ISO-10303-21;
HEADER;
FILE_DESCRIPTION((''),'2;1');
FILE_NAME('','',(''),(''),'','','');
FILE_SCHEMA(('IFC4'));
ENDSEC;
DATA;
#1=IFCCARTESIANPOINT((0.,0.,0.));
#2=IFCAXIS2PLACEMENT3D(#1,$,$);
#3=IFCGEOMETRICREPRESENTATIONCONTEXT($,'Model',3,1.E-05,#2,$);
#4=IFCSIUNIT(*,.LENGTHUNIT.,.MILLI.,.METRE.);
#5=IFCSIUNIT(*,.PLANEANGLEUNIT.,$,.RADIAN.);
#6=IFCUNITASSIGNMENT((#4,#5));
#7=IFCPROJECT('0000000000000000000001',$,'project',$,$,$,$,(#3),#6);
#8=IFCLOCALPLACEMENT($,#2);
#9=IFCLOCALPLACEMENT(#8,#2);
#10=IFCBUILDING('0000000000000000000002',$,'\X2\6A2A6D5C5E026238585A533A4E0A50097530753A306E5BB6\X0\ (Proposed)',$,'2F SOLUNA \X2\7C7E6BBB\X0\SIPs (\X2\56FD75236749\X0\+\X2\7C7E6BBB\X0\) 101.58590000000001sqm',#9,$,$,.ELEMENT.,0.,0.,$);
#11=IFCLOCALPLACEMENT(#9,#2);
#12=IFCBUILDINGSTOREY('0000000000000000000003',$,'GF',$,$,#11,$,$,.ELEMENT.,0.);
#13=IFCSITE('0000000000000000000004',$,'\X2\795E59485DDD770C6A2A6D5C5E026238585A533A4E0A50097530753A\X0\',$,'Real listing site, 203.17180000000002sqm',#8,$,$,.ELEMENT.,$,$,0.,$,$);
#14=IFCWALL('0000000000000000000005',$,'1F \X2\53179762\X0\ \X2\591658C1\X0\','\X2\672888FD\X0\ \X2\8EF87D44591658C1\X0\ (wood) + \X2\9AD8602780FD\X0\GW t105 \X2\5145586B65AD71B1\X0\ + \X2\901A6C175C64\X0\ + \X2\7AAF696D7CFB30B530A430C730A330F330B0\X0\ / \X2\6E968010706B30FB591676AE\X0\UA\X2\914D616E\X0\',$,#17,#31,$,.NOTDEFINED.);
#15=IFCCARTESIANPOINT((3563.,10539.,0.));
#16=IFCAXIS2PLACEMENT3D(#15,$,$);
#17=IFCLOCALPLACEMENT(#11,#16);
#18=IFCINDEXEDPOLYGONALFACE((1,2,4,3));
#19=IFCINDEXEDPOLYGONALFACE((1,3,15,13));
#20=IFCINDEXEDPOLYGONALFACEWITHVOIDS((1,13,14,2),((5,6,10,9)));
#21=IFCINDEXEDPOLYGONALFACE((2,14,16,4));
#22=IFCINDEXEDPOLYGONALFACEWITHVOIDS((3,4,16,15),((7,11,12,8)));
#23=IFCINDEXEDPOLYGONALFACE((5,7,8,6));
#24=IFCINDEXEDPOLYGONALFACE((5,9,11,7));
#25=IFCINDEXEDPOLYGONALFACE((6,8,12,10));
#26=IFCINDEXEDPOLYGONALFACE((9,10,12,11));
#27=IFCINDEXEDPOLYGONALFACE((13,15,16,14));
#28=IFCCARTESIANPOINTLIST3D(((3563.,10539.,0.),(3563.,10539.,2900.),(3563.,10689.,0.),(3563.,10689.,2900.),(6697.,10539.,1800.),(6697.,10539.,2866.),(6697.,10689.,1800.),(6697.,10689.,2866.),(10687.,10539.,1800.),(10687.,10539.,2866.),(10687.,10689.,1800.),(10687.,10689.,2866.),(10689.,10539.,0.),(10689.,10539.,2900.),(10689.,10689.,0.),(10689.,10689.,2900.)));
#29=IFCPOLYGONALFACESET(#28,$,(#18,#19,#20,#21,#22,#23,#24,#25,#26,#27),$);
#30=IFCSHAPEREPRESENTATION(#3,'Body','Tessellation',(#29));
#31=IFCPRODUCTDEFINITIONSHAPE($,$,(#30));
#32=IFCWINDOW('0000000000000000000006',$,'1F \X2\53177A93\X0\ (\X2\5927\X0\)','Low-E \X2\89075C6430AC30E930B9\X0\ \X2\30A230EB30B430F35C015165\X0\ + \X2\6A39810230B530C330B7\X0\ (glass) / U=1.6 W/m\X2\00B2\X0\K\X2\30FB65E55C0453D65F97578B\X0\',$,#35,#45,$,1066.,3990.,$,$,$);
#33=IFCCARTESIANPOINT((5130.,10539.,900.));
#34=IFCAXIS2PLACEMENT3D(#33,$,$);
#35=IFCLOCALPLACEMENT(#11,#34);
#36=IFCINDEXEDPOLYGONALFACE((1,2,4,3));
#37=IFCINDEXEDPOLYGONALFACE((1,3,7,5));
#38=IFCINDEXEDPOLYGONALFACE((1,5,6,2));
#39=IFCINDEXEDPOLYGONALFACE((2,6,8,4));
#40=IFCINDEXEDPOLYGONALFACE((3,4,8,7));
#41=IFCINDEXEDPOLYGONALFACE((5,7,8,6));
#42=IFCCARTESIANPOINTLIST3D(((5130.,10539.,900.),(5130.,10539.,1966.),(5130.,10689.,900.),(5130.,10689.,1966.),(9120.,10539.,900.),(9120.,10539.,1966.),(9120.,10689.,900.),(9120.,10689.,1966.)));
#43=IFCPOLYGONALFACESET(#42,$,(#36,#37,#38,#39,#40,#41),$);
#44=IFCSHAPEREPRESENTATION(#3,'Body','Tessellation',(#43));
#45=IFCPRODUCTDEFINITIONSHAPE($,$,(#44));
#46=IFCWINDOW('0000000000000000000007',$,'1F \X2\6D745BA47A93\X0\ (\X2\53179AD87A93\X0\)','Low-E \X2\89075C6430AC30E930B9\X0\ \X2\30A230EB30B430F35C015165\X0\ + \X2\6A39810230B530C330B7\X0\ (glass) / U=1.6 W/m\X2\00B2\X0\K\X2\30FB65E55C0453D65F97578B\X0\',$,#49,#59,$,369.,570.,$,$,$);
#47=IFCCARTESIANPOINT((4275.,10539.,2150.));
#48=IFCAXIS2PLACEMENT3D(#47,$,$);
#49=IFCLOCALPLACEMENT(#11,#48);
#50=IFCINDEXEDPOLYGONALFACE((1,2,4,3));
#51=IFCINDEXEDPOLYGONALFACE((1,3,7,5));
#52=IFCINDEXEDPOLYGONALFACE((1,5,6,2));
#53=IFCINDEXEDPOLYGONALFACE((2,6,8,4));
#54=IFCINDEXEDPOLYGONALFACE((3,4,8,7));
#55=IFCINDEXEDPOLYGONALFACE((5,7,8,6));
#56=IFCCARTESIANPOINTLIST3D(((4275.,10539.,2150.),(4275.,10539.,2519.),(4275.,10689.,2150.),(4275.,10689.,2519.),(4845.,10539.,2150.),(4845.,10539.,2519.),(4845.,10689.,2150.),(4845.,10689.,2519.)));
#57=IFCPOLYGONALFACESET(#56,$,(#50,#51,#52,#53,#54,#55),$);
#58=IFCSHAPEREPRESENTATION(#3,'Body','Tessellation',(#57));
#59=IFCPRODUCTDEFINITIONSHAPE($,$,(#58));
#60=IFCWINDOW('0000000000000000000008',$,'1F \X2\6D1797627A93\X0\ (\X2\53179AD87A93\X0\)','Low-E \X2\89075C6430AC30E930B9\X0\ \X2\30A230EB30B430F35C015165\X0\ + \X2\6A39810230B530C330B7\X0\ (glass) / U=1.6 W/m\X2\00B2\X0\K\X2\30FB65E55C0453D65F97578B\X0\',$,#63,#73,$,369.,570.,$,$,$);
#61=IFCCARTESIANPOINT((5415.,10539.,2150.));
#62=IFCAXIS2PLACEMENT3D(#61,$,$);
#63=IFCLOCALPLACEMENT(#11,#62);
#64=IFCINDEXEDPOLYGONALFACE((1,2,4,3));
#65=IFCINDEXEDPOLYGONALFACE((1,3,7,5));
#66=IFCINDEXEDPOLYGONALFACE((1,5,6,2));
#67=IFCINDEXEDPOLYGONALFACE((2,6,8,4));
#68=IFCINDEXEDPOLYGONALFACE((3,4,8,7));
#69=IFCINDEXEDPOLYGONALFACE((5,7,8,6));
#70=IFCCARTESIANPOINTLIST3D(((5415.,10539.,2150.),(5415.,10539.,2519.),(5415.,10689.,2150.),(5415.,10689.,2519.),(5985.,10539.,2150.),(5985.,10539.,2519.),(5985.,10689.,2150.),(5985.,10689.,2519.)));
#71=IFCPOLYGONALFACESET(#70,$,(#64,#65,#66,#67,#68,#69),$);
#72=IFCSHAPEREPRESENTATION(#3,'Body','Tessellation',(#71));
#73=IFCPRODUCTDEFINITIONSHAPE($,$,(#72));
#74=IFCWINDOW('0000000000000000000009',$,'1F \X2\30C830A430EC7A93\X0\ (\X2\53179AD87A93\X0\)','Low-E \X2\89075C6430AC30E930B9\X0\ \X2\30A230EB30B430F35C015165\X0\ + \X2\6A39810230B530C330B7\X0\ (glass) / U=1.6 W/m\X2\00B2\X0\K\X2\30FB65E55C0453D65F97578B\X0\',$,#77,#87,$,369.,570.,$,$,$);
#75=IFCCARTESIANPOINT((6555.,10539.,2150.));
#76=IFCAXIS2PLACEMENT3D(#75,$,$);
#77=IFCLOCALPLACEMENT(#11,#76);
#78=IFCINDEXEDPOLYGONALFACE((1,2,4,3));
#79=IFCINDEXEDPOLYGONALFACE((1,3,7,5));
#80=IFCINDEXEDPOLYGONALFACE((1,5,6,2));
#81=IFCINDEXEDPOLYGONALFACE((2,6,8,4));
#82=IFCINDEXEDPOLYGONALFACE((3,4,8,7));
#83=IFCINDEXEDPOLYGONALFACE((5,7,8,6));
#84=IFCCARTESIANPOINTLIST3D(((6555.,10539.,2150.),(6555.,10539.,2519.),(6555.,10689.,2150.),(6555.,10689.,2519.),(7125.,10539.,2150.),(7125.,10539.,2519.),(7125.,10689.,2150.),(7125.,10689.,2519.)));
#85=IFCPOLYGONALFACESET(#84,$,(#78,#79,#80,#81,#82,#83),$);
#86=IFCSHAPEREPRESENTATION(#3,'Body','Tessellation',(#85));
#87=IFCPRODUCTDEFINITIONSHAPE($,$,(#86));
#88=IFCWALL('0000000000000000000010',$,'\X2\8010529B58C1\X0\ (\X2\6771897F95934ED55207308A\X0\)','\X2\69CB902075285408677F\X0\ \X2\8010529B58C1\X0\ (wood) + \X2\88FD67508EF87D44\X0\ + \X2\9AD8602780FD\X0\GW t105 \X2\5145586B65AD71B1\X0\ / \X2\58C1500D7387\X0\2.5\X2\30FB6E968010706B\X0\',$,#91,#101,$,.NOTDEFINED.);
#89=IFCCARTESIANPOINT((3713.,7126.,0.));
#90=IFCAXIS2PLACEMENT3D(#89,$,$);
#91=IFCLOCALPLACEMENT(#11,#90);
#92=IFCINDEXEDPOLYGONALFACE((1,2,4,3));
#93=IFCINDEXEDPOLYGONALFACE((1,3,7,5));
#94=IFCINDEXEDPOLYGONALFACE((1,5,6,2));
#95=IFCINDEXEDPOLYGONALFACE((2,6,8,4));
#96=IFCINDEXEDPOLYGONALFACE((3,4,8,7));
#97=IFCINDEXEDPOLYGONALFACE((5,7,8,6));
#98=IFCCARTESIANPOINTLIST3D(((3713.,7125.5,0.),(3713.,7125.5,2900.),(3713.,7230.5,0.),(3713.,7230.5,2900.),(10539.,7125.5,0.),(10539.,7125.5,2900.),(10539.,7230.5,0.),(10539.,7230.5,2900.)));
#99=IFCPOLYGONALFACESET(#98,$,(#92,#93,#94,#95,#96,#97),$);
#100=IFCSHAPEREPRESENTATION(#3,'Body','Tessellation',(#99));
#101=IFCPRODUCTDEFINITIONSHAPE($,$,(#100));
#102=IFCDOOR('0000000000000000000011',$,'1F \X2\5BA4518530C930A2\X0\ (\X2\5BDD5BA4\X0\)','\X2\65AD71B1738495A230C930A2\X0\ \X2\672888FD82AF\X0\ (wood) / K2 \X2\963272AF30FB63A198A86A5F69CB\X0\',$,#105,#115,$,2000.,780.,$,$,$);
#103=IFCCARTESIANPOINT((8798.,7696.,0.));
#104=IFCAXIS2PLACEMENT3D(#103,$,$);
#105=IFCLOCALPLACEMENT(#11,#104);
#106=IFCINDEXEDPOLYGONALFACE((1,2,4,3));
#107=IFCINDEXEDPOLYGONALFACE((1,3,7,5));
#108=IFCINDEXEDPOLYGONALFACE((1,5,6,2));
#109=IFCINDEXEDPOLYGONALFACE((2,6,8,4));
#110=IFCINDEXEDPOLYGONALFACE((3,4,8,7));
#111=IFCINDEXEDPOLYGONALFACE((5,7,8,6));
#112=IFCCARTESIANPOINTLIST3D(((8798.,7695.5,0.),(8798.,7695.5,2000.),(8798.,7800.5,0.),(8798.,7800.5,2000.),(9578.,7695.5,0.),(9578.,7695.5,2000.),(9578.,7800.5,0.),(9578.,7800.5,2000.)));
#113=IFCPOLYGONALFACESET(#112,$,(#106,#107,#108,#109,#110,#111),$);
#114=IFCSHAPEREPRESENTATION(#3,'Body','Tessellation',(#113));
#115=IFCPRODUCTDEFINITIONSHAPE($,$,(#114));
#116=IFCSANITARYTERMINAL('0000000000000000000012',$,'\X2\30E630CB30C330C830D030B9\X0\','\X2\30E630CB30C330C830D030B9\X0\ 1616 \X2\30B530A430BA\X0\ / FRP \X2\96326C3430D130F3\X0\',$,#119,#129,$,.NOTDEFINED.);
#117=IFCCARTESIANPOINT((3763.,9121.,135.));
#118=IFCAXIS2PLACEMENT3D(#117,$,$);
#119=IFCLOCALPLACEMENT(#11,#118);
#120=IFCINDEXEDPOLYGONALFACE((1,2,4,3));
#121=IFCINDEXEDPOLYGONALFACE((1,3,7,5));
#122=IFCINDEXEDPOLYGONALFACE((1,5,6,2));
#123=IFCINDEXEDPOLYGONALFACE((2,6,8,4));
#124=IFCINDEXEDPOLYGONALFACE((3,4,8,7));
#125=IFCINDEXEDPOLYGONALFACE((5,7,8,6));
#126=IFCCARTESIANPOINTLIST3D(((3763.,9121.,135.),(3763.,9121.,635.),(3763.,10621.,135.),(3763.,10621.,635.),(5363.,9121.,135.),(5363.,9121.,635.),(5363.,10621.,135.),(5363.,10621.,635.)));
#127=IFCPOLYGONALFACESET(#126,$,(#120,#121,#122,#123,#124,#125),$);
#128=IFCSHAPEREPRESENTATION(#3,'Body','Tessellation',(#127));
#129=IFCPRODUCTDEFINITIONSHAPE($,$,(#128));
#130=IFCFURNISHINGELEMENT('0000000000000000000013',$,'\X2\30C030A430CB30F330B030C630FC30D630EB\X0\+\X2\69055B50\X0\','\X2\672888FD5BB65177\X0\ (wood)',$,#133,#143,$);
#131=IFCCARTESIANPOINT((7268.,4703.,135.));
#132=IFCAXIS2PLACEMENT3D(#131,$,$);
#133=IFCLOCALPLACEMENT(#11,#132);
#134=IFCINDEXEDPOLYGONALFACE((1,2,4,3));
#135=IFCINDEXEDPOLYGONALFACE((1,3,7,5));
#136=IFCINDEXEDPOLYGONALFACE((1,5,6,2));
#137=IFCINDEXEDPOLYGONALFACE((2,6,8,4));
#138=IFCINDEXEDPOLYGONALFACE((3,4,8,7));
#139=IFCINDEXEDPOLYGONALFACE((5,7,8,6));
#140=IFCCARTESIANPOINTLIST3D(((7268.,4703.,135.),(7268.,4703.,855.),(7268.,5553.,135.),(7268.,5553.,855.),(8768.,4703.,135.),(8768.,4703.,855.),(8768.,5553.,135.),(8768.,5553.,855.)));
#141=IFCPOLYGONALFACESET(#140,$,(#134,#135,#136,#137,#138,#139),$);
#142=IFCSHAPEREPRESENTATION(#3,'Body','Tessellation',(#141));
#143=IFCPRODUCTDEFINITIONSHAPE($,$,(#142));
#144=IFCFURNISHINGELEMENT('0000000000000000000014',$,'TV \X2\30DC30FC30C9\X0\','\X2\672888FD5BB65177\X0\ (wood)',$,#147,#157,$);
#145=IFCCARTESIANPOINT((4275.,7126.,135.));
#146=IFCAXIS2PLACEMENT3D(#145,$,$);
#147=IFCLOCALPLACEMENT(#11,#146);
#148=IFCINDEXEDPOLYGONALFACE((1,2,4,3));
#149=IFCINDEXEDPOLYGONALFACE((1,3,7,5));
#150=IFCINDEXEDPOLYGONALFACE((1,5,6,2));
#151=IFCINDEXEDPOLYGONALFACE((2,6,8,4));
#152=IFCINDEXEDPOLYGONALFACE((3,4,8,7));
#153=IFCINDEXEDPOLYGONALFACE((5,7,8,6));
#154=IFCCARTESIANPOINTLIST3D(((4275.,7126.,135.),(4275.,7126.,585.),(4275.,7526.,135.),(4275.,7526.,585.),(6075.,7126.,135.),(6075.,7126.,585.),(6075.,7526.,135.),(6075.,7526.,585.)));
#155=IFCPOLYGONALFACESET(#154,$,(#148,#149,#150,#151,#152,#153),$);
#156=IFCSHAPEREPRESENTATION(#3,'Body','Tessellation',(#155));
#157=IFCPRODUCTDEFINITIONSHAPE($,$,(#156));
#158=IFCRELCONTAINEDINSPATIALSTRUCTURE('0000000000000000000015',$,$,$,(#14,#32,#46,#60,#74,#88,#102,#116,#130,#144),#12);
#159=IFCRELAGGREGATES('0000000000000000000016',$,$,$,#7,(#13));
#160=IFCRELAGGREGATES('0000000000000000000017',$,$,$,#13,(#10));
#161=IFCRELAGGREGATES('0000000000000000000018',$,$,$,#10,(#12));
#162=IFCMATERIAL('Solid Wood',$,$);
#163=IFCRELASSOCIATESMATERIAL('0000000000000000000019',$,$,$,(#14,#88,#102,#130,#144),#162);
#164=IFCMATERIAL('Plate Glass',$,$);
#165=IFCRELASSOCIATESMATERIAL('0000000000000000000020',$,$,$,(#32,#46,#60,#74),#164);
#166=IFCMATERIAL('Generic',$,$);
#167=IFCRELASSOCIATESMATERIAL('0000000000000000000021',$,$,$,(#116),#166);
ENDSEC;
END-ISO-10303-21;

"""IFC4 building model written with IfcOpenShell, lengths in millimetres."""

from ifc_helpers import new_model, si_unit, frame, frame_2d, origin, place, context, project, spatial, rectangle, extrude, material, element, fill, save


model = new_model("IFC4")

# Units and contexts
model_context = context("Model", 3, precision=1e-05, world=origin())
ifc_project = project(units=[si_unit("LENGTHUNIT", "METRE", prefix="MILLI"), si_unit("PLANEANGLEUNIT", "RADIAN")], contexts=[model_context])

# Site, building, storey
site_placement = place(None, origin())
site = spatial("IfcSite", under=ifc_project, at=site_placement, Name="神奈川県横浜市戸塚区上倉田町", ObjectType="Real listing site, 203.17180000000002sqm", CompositionType="ELEMENT", RefElevation=0.0)
building_placement = place(site_placement, origin())
building = spatial("IfcBuilding", under=site, at=building_placement, Name="横浜市戸塚区上倉田町の家 (Proposed)", ObjectType="2F SOLUNA 籾殻SIPs (国産杉+籾殻) 101.58590000000001sqm", CompositionType="ELEMENT", ElevationOfRefHeight=0.0, ElevationOfTerrain=0.0)
storey_placement = place(building_placement, origin())
storey = spatial("IfcBuildingStorey", under=building, at=storey_placement, Name="GF", CompositionType="ELEMENT", Elevation=0.0)

# Wall, openings, windows
ifc_material_1 = material(Name="Solid Wood")
wall_1_placement = place(storey_placement, frame((3563.0, 10539.0, 0.0)))
wall_1 = element("IfcWall", 1, at=wall_1_placement, inside=storey, material=ifc_material_1, Name="1F 北面 外壁", Description="木製 軸組外壁 (wood) + 高性能GW t105 充填断熱 + 通気層 + 窯業系サイディング / 準耐火・外皮UA配慮", PredefinedType="NOTDEFINED", context=model_context, shape_type="SweptSolid", body=[
    extrude(rectangle(XDim=7126.0, YDim=150.0, at=frame_2d((3563.0, 75.0))), frame((3563.0, 10539.0, 0.0)), (0.0, 0.0, 1.0), 2900.0),
])
opening_1_placement = place(storey_placement, frame((5130.0, 10539.0, 900.0)))
opening_1 = element("IfcOpeningElement", 2, at=opening_1_placement, cuts=wall_1, PredefinedType="NOTDEFINED", context=model_context, shape_type="SweptSolid", body=[
    extrude(rectangle(XDim=3990.0, YDim=150.0, at=frame_2d((1995.0, 75.0))), frame((5130.0, 10539.0, 900.0)), (0.0, 0.0, 1.0), 1066.0),
])
opening_2_placement = place(storey_placement, frame((4275.0, 10539.0, 2150.0)))
opening_2 = element("IfcOpeningElement", 3, at=opening_2_placement, cuts=wall_1, PredefinedType="NOTDEFINED", context=model_context, shape_type="SweptSolid", body=[
    extrude(rectangle(XDim=570.0, YDim=150.0, at=frame_2d((285.0, 75.0))), frame((4275.0, 10539.0, 2150.0)), (0.0, 0.0, 1.0), 369.0),
])
opening_3_placement = place(storey_placement, frame((5415.0, 10539.0, 2150.0)))
opening_3 = element("IfcOpeningElement", 4, at=opening_3_placement, cuts=wall_1, PredefinedType="NOTDEFINED", context=model_context, shape_type="SweptSolid", body=[
    extrude(rectangle(XDim=570.0, YDim=150.0, at=frame_2d((285.0, 75.0))), frame((5415.0, 10539.0, 2150.0)), (0.0, 0.0, 1.0), 369.0),
])
opening_4_placement = place(storey_placement, frame((6555.0, 10539.0, 2150.0)))
opening_4 = element("IfcOpeningElement", 5, at=opening_4_placement, cuts=wall_1, PredefinedType="NOTDEFINED", context=model_context, shape_type="SweptSolid", body=[
    extrude(rectangle(XDim=570.0, YDim=150.0, at=frame_2d((285.0, 75.0))), frame((6555.0, 10539.0, 2150.0)), (0.0, 0.0, 1.0), 369.0),
])
ifc_material_2 = material(Name="Plate Glass")
window_1_placement = place(storey_placement, frame((5130.0, 10539.0, 900.0)))
window_1 = element("IfcWindow", 6, at=window_1_placement, inside=storey, material=ifc_material_2, Name="1F 北窓 (大)", Description="Low-E 複層ガラス アルゴン封入 + 樹脂サッシ (glass) / U=1.6 W/m²K・日射取得型", OverallHeight=1066.0, OverallWidth=3990.0, context=model_context, shape_type="SweptSolid", body=[
    extrude(rectangle(XDim=3990.0, YDim=150.0, at=frame_2d((1995.0, 75.0))), frame((5130.0, 10539.0, 900.0)), (0.0, 0.0, 1.0), 1066.0),
])
fill(opening_1, window_1)
window_2_placement = place(storey_placement, frame((4275.0, 10539.0, 2150.0)))
window_2 = element("IfcWindow", 7, at=window_2_placement, inside=storey, material=ifc_material_2, Name="1F 浴室窓 (北高窓)", Description="Low-E 複層ガラス アルゴン封入 + 樹脂サッシ (glass) / U=1.6 W/m²K・日射取得型", OverallHeight=369.0, OverallWidth=570.0, context=model_context, shape_type="SweptSolid", body=[
    extrude(rectangle(XDim=570.0, YDim=150.0, at=frame_2d((285.0, 75.0))), frame((4275.0, 10539.0, 2150.0)), (0.0, 0.0, 1.0), 369.0),
])
fill(opening_2, window_2)
window_3_placement = place(storey_placement, frame((5415.0, 10539.0, 2150.0)))
window_3 = element("IfcWindow", 8, at=window_3_placement, inside=storey, material=ifc_material_2, Name="1F 洗面窓 (北高窓)", Description="Low-E 複層ガラス アルゴン封入 + 樹脂サッシ (glass) / U=1.6 W/m²K・日射取得型", OverallHeight=369.0, OverallWidth=570.0, context=model_context, shape_type="SweptSolid", body=[
    extrude(rectangle(XDim=570.0, YDim=150.0, at=frame_2d((285.0, 75.0))), frame((5415.0, 10539.0, 2150.0)), (0.0, 0.0, 1.0), 369.0),
])
fill(opening_3, window_3)
window_4_placement = place(storey_placement, frame((6555.0, 10539.0, 2150.0)))
window_4 = element("IfcWindow", 9, at=window_4_placement, inside=storey, material=ifc_material_2, Name="1F トイレ窓 (北高窓)", Description="Low-E 複層ガラス アルゴン封入 + 樹脂サッシ (glass) / U=1.6 W/m²K・日射取得型", OverallHeight=369.0, OverallWidth=570.0, context=model_context, shape_type="SweptSolid", body=[
    extrude(rectangle(XDim=570.0, YDim=150.0, at=frame_2d((285.0, 75.0))), frame((6555.0, 10539.0, 2150.0)), (0.0, 0.0, 1.0), 369.0),
])
fill(opening_4, window_4)

# Wall
wall_2_placement = place(storey_placement, frame((3713.0, 7126.0, 0.0)))
element("IfcWall", 10, at=wall_2_placement, inside=storey, material=ifc_material_1, Name="耐力壁 (東西間仕切り)", Description="構造用合板 耐力壁 (wood) + 製材軸組 + 高性能GW t105 充填断熱 / 壁倍率2.5・準耐火", PredefinedType="NOTDEFINED", context=model_context, shape_type="SweptSolid", body=[
    extrude(rectangle(XDim=6826.0, YDim=105.0, at=frame_2d((3413.0, 52.0))), frame((3713.0, 7126.0, 0.0)), (0.0, 0.0, 1.0), 2900.0),
])

# Door
door_1_placement = place(storey_placement, frame((8798.0, 7696.0, 0.0)))
element("IfcDoor", 11, at=door_1_placement, inside=storey, material=ifc_material_1, Name="1F 室内ドア (寝室)", Description="断熱玄関ドア 木製芯 (wood) / K2 防犯・採風機構", OverallHeight=2000.0, OverallWidth=780.0, context=model_context, shape_type="SweptSolid", body=[
    extrude(rectangle(XDim=780.0, YDim=105.0, at=frame_2d((390.0, 52.0))), frame((8798.0, 7696.0, 0.0)), (0.0, 0.0, 1.0), 2000.0),
])

# Sanitary terminal
ifc_material_3 = material(Name="Generic")
sanitary_terminal_placement = place(storey_placement, frame((3763.0, 9121.0, 135.0)))
element("IfcSanitaryTerminal", 12, at=sanitary_terminal_placement, inside=storey, material=ifc_material_3, Name="ユニットバス", Description="ユニットバス 1616 サイズ / FRP 防水パン", PredefinedType="NOTDEFINED", context=model_context, shape_type="SweptSolid", body=[
    extrude(rectangle(XDim=1600.0, YDim=1500.0, at=frame_2d((800.0, 750.0))), frame((3763.0, 9121.0, 135.0)), (0.0, 0.0, 1.0), 500.0),
])

# Furnishing elements
furnishing_1_placement = place(storey_placement, frame((7268.0, 4703.0, 135.0)))
element("IfcFurnishingElement", 13, at=furnishing_1_placement, inside=storey, material=ifc_material_1, Name="ダイニングテーブル+椅子", Description="木製家具 (wood)", context=model_context, shape_type="SweptSolid", body=[
    extrude(rectangle(XDim=1500.0, YDim=850.0, at=frame_2d((750.0, 425.0))), frame((7268.0, 4703.0, 135.0)), (0.0, 0.0, 1.0), 720.0),
])
furnishing_2_placement = place(storey_placement, frame((4275.0, 7126.0, 135.0)))
element("IfcFurnishingElement", 14, at=furnishing_2_placement, inside=storey, material=ifc_material_1, Name="TV ボード", Description="木製家具 (wood)", context=model_context, shape_type="SweptSolid", body=[
    extrude(rectangle(XDim=1800.0, YDim=400.0, at=frame_2d((900.0, 200.0))), frame((4275.0, 7126.0, 135.0)), (0.0, 0.0, 1.0), 450.0),
])

save(model, "model.ifc")
